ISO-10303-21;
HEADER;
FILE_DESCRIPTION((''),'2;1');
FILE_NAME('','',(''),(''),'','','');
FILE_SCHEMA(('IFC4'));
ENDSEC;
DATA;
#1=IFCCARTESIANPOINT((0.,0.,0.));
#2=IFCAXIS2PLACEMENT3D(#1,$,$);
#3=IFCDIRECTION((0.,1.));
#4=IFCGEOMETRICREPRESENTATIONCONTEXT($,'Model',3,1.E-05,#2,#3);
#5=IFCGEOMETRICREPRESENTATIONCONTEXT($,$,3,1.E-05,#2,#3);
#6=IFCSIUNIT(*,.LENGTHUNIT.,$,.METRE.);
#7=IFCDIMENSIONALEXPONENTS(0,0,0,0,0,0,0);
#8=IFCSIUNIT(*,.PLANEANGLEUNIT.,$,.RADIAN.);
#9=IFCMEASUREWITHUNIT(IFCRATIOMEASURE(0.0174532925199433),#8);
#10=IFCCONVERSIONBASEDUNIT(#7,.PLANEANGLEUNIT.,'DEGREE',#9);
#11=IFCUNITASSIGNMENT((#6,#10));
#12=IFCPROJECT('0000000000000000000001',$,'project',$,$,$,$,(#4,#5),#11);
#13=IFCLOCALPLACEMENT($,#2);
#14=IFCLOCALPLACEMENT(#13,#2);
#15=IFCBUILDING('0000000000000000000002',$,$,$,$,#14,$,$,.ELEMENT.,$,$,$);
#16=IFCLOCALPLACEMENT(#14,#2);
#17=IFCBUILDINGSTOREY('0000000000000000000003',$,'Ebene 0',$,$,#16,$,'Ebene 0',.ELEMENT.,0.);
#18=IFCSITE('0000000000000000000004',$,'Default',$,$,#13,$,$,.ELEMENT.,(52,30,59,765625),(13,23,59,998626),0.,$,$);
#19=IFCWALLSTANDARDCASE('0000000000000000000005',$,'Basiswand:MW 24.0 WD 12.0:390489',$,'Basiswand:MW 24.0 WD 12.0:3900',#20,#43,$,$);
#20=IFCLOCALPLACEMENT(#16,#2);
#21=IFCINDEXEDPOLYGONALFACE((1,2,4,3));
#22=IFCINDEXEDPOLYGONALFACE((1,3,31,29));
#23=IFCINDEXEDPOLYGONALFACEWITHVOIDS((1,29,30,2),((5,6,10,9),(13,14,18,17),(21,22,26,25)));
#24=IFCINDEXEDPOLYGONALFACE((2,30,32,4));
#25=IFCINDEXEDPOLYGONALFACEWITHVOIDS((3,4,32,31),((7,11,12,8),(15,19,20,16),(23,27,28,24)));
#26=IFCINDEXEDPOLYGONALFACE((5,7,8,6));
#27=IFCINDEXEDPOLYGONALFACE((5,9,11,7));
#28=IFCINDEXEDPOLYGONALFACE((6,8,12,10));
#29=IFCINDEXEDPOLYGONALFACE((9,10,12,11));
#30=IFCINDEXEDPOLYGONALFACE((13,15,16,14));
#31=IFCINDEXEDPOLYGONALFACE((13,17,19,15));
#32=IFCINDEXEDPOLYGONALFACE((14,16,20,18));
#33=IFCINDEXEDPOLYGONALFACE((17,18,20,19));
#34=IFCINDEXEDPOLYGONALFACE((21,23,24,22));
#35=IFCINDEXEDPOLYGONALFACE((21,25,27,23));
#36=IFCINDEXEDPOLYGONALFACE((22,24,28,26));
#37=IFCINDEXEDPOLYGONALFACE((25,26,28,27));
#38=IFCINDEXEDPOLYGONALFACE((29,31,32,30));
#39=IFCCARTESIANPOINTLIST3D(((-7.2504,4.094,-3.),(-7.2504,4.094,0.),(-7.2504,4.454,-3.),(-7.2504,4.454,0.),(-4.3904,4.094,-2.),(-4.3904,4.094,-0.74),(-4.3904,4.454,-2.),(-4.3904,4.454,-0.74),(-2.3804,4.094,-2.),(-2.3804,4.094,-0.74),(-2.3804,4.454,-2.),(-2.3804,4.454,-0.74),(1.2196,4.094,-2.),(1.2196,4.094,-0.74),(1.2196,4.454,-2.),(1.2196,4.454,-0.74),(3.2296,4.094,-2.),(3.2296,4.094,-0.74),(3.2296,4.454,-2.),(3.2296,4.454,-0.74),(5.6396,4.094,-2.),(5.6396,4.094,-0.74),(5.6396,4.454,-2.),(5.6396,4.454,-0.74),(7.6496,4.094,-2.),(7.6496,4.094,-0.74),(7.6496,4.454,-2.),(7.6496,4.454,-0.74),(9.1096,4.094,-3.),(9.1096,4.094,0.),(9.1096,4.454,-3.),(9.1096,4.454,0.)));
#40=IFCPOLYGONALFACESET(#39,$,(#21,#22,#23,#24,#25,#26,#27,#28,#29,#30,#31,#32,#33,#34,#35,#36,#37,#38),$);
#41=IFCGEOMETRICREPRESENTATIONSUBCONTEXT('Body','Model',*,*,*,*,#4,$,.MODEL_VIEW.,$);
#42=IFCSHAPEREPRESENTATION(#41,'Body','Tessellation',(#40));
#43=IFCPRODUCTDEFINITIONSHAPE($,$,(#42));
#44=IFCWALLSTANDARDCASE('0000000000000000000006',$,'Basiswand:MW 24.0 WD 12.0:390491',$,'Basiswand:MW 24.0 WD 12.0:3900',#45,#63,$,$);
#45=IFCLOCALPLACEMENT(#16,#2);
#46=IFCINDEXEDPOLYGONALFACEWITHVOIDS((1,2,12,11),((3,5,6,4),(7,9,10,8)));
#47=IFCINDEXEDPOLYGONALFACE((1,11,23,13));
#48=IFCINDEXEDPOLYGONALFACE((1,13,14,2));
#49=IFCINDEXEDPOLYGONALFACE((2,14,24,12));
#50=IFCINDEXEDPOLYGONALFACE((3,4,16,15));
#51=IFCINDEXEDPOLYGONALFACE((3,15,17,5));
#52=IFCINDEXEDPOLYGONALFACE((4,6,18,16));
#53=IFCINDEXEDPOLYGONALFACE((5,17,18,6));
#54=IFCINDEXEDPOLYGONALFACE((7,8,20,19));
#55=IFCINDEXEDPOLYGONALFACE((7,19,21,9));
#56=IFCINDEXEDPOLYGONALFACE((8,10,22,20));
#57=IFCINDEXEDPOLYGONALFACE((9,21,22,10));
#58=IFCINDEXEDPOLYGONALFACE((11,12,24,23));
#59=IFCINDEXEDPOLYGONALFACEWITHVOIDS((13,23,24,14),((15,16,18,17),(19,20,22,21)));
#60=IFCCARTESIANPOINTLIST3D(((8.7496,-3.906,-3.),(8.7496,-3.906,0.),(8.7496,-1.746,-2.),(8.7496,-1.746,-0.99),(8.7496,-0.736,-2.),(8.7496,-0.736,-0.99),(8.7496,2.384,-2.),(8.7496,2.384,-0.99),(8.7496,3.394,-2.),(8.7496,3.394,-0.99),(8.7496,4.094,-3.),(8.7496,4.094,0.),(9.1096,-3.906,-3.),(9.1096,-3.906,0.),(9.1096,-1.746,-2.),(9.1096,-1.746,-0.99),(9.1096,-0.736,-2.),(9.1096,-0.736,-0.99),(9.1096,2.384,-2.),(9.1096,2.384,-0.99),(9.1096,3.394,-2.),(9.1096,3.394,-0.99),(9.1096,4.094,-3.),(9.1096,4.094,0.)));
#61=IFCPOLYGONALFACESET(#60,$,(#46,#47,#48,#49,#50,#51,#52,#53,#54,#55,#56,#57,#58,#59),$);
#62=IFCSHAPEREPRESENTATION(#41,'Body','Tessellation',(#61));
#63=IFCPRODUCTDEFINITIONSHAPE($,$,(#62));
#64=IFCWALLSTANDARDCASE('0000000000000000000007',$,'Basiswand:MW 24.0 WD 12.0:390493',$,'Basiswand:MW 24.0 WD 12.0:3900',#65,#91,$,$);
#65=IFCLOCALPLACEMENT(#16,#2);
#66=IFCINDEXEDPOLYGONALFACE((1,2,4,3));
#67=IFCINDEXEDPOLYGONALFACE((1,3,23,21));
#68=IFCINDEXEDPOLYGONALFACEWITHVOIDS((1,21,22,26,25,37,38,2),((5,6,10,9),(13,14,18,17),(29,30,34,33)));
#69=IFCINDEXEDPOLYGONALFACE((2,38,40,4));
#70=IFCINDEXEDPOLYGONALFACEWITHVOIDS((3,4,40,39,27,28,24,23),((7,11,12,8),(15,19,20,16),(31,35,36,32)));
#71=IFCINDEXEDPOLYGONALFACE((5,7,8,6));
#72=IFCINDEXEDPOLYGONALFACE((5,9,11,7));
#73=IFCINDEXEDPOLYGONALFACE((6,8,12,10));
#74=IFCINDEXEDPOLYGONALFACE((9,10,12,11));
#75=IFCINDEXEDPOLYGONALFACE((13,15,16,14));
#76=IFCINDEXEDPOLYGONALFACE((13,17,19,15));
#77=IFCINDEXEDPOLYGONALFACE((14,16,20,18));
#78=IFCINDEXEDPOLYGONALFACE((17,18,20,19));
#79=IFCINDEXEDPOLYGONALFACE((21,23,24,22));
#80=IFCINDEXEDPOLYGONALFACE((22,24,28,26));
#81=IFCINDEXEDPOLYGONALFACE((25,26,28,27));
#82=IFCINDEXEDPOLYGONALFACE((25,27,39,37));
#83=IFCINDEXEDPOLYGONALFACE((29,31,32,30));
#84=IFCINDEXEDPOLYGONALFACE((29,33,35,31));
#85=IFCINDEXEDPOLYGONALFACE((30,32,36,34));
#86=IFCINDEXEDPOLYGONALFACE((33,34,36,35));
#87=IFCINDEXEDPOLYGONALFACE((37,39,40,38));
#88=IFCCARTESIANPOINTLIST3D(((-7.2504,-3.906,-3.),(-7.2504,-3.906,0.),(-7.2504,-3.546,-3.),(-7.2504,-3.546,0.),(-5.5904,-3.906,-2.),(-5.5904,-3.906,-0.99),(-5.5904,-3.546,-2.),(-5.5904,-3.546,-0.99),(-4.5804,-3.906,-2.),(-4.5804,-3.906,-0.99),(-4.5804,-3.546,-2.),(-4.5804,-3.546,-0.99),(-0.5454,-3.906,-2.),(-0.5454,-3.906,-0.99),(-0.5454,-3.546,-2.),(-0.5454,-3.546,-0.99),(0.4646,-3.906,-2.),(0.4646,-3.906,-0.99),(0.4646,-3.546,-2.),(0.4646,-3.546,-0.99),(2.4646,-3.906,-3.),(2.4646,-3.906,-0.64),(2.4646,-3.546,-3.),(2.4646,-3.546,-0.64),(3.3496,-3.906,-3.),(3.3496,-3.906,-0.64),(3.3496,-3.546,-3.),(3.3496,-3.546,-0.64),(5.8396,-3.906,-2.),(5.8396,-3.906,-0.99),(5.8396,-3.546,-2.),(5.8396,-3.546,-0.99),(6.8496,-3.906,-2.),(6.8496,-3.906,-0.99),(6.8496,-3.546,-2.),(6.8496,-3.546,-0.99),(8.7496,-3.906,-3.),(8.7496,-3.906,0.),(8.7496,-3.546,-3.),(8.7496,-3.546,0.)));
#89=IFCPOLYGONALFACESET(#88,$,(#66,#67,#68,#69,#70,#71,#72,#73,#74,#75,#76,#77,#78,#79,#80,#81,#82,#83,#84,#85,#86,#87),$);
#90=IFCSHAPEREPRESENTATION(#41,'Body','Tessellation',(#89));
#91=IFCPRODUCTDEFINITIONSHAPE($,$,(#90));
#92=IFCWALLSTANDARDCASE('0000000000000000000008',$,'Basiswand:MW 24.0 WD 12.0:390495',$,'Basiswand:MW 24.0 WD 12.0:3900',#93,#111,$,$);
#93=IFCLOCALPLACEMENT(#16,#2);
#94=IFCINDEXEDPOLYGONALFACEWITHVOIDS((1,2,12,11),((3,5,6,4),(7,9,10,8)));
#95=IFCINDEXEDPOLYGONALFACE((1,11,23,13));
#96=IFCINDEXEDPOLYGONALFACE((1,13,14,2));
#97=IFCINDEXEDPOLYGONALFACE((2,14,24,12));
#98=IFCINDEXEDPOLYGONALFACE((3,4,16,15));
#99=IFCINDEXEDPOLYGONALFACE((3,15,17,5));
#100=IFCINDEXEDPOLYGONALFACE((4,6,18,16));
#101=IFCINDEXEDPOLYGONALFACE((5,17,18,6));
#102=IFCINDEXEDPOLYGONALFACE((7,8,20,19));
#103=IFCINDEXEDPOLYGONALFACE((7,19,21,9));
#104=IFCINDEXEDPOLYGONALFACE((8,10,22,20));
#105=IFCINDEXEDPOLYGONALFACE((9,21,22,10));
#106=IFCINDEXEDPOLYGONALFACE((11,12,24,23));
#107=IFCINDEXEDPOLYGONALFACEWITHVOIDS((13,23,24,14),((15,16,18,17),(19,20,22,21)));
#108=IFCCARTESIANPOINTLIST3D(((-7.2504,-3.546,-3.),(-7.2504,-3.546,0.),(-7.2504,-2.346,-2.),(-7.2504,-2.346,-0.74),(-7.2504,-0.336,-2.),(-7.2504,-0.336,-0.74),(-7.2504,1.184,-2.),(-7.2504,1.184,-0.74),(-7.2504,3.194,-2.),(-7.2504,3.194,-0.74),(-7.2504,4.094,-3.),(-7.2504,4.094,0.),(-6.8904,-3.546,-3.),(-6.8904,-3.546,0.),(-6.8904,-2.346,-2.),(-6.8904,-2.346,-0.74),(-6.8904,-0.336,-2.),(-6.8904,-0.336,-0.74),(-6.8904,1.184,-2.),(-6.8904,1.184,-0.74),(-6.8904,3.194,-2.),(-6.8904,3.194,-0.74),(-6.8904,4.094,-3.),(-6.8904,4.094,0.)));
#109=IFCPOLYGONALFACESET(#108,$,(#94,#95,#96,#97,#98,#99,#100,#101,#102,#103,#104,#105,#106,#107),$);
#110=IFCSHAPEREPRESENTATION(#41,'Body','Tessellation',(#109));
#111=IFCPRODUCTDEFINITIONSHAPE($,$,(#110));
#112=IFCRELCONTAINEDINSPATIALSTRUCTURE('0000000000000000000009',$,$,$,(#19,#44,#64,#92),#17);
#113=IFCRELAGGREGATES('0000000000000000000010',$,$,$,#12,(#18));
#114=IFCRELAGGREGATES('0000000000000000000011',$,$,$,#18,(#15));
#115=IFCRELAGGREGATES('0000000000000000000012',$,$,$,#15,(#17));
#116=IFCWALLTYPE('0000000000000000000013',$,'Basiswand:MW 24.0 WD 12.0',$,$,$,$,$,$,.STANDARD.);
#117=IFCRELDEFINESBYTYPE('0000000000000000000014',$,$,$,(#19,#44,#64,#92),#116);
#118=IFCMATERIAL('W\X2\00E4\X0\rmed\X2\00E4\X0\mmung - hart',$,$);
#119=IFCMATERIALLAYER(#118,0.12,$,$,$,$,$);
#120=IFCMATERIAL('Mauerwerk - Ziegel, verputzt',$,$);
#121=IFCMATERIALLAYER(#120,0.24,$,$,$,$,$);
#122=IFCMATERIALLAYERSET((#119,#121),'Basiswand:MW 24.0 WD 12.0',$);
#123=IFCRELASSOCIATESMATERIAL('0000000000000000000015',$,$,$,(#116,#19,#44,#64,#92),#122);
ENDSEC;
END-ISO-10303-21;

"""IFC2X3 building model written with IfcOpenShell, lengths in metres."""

from ifc_helpers import new_model, entity, si_unit, converted_unit, direction, frame, frame_2d, origin, place, context, subcontext, project, spatial, rectangle, extrude, material, layer, layer_set, layer_usage, type_object, element, save


model = new_model("IFC2X3")

# Units and contexts
model_context = context("Model", 3, precision=1e-05, world=origin(), true_north=direction((0.0, 1.0)))
context_of_model = context(None, 3, precision=1e-05, world=origin(), true_north=direction((0.0, 1.0)))
body_context = subcontext(model_context, "Body", "Model", "MODEL_VIEW")
ifc_project = project(units=[si_unit("LENGTHUNIT", "METRE"), converted_unit("PLANEANGLEUNIT", "DEGREE", entity("IfcRatioMeasure", 0.0174532925199433), si_unit("PLANEANGLEUNIT", "RADIAN"), dimensions=[0, 0, 0, 0, 0, 0, 0])], contexts=[model_context, context_of_model])

# Site, building, storey
site_placement = place(None, origin())
site = spatial("IfcSite", under=ifc_project, at=site_placement, Name="Default", CompositionType="ELEMENT", RefLatitude=(52, 30, 59, 765625), RefLongitude=(13, 23, 59, 998626), RefElevation=0.0)
building_placement = place(site_placement, origin())
building = spatial("IfcBuilding", under=site, at=building_placement, CompositionType="ELEMENT")
storey_placement = place(building_placement, origin())
storey = spatial("IfcBuildingStorey", under=building, at=storey_placement, Name="Ebene 0", LongName="Ebene 0", CompositionType="ELEMENT", Elevation=0.0)

# Walls, openings
ifc_material_1 = material(Name="Wärmedämmung - hart")
ifc_layer_1 = layer(ifc_material_1, 0.12)
ifc_material_2 = material(Name="Mauerwerk - Ziegel, verputzt")
ifc_layer_2 = layer(ifc_material_2, 0.24)
ifc_layer_set = layer_set([ifc_layer_1, ifc_layer_2], Name="Basiswand:MW 24.0 WD 12.0")
ifc_layer_usage_1 = layer_usage(ifc_layer_set, "AXIS2", "NEGATIVE", 0.18)
wall_type = type_object("IfcWallType", Name="Basiswand:MW 24.0 WD 12.0", PredefinedType="STANDARD", material=ifc_layer_set)
wall_1_placement = place(storey_placement, frame((-7.2504, 4.274, -3.0)))
wall_1 = element("IfcWallStandardCase", 1, at=wall_1_placement, inside=storey, type_object=wall_type, material=ifc_layer_usage_1, Name="Basiswand:MW 24.0 WD 12.0:390489", ObjectType="Basiswand:MW 24.0 WD 12.0:3900", context=body_context, shape_type="SweptSolid", body=[
    extrude(rectangle(XDim=16.36, YDim=0.36, at=frame_2d((8.18, 0.0), x_axis=(-1.0, 0.0))), origin(), (0.0, 0.0, 1.0), 3.0),
])
opening_1_placement = place(wall_1_placement, frame((2.86, -0.18, 1.0)))
element("IfcOpeningElement", 2, at=opening_1_placement, cuts=wall_1, ObjectType="Opening", context=body_context, shape_type="SweptSolid", body=[
    extrude(rectangle(XDim=1.26, YDim=2.01, at=frame_2d((0.63, 1.005), x_axis=(1.0, 0.0))), frame((0.0, 0.0, 0.0), z_axis=(0.0, 1.0, 0.0), x_axis=(0.0, 0.0, 1.0)), (0.0, 0.0, 1.0), 0.36),
])
opening_2_placement = place(wall_1_placement, frame((8.47, -0.18, 1.0)))
element("IfcOpeningElement", 3, at=opening_2_placement, cuts=wall_1, ObjectType="Opening", context=body_context, shape_type="SweptSolid", body=[
    extrude(rectangle(XDim=1.26, YDim=2.01, at=frame_2d((0.63, 1.005), x_axis=(1.0, 0.0))), frame((0.0, 0.0, 0.0), z_axis=(0.0, 1.0, 0.0), x_axis=(0.0, 0.0, 1.0)), (0.0, 0.0, 1.0), 0.36),
])
opening_3_placement = place(wall_1_placement, frame((12.89, -0.18, 1.0)))
element("IfcOpeningElement", 4, at=opening_3_placement, cuts=wall_1, ObjectType="Opening", context=body_context, shape_type="SweptSolid", body=[
    extrude(rectangle(XDim=1.26, YDim=2.01, at=frame_2d((0.63, 1.005), x_axis=(1.0, 0.0))), frame((0.0, 0.0, 0.0), z_axis=(0.0, 1.0, 0.0), x_axis=(0.0, 0.0, 1.0)), (0.0, 0.0, 1.0), 0.36),
])
ifc_layer_usage_2 = layer_usage(ifc_layer_set, "AXIS2", "NEGATIVE", 0.18)
wall_2_placement = place(storey_placement, frame((8.9296, 4.094, -3.0), z_axis=(0.0, 0.0, 1.0), x_axis=(0.0, -1.0, 0.0)))
wall_2 = element("IfcWallStandardCase", 5, at=wall_2_placement, inside=storey, type_object=wall_type, material=ifc_layer_usage_2, Name="Basiswand:MW 24.0 WD 12.0:390491", ObjectType="Basiswand:MW 24.0 WD 12.0:3900", context=body_context, shape_type="SweptSolid", body=[
    extrude(rectangle(XDim=8.0, YDim=0.36, at=frame_2d((4.0, 0.0), x_axis=(-1.0, 0.0))), origin(), (0.0, 0.0, 1.0), 3.0),
])
opening_4_placement = place(wall_2_placement, frame((4.83, -0.18, 1.0)))
element("IfcOpeningElement", 6, at=opening_4_placement, cuts=wall_2, ObjectType="Opening", context=body_context, shape_type="SweptSolid", body=[
    extrude(rectangle(XDim=1.01, YDim=1.01, at=frame_2d((0.505, 0.505), x_axis=(1.0, 0.0))), frame((0.0, 0.0, 0.0), z_axis=(0.0, 1.0, 0.0), x_axis=(0.0, 0.0, 1.0)), (0.0, 0.0, 1.0), 0.36),
])
opening_5_placement = place(wall_2_placement, frame((0.7, -0.18, 1.0)))
element("IfcOpeningElement", 7, at=opening_5_placement, cuts=wall_2, ObjectType="Opening", context=body_context, shape_type="SweptSolid", body=[
    extrude(rectangle(XDim=1.01, YDim=1.01, at=frame_2d((0.505, 0.505), x_axis=(1.0, 0.0))), frame((0.0, 0.0, 0.0), z_axis=(0.0, 1.0, 0.0), x_axis=(0.0, 0.0, 1.0)), (0.0, 0.0, 1.0), 0.36),
])
ifc_layer_usage_3 = layer_usage(ifc_layer_set, "AXIS2", "NEGATIVE", 0.18)
wall_3_placement = place(storey_placement, frame((8.7496, -3.726, -3.0), z_axis=(0.0, 0.0, 1.0), x_axis=(-1.0, 0.0, 0.0)))
wall_3 = element("IfcWallStandardCase", 8, at=wall_3_placement, inside=storey, type_object=wall_type, material=ifc_layer_usage_3, Name="Basiswand:MW 24.0 WD 12.0:390493", ObjectType="Basiswand:MW 24.0 WD 12.0:3900", context=body_context, shape_type="SweptSolid", body=[
    extrude(rectangle(XDim=16.0, YDim=0.36, at=frame_2d((8.0, 0.0), x_axis=(-1.0, 0.0))), origin(), (0.0, 0.0, 1.0), 3.0),
])
opening_6_placement = place(wall_3_placement, frame((5.4, -0.18, 0.0)))
element("IfcOpeningElement", 9, at=opening_6_placement, cuts=wall_3, ObjectType="Opening", context=body_context, shape_type="SweptSolid", body=[
    extrude(rectangle(XDim=2.36, YDim=0.885, at=frame_2d((1.18, 0.4425), x_axis=(1.0, 0.0))), frame((0.0, 0.0, 0.0), z_axis=(0.0, 1.0, 0.0), x_axis=(0.0, 0.0, 1.0)), (0.0, 0.0, 1.0), 0.36),
])
opening_7_placement = place(wall_3_placement, frame((1.9, -0.18, 1.0)))
element("IfcOpeningElement", 10, at=opening_7_placement, cuts=wall_3, ObjectType="Opening", context=body_context, shape_type="SweptSolid", body=[
    extrude(rectangle(XDim=1.01, YDim=1.01, at=frame_2d((0.505, 0.505), x_axis=(1.0, 0.0))), frame((0.0, 0.0, 0.0), z_axis=(0.0, 1.0, 0.0), x_axis=(0.0, 0.0, 1.0)), (0.0, 0.0, 1.0), 0.36),
])
opening_8_placement = place(wall_3_placement, frame((8.285, -0.18, 1.0)))
element("IfcOpeningElement", 11, at=opening_8_placement, cuts=wall_3, ObjectType="Opening", context=body_context, shape_type="SweptSolid", body=[
    extrude(rectangle(XDim=1.01, YDim=1.01, at=frame_2d((0.505, 0.505), x_axis=(1.0, 0.0))), frame((0.0, 0.0, 0.0), z_axis=(0.0, 1.0, 0.0), x_axis=(0.0, 0.0, 1.0)), (0.0, 0.0, 1.0), 0.36),
])
opening_9_placement = place(wall_3_placement, frame((13.33, -0.18, 1.0)))
element("IfcOpeningElement", 12, at=opening_9_placement, cuts=wall_3, ObjectType="Opening", context=body_context, shape_type="SweptSolid", body=[
    extrude(rectangle(XDim=1.01, YDim=1.01, at=frame_2d((0.505, 0.505), x_axis=(1.0, 0.0))), frame((0.0, 0.0, 0.0), z_axis=(0.0, 1.0, 0.0), x_axis=(0.0, 0.0, 1.0)), (0.0, 0.0, 1.0), 0.36),
])
ifc_layer_usage_4 = layer_usage(ifc_layer_set, "AXIS2", "NEGATIVE", 0.18)
wall_4_placement = place(storey_placement, frame((-7.0704, -3.546, -3.0), z_axis=(0.0, 0.0, 1.0), x_axis=(0.0, 1.0, 0.0)))
wall_4 = element("IfcWallStandardCase", 13, at=wall_4_placement, inside=storey, type_object=wall_type, material=ifc_layer_usage_4, Name="Basiswand:MW 24.0 WD 12.0:390495", ObjectType="Basiswand:MW 24.0 WD 12.0:3900", context=body_context, shape_type="SweptSolid", body=[
    extrude(rectangle(XDim=7.64, YDim=0.36, at=frame_2d((3.82, 0.0), x_axis=(-1.0, 0.0))), origin(), (0.0, 0.0, 1.0), 3.0),
])
opening_10_placement = place(wall_4_placement, frame((1.2, -0.18, 1.0)))
element("IfcOpeningElement", 14, at=opening_10_placement, cuts=wall_4, ObjectType="Opening", context=body_context, shape_type="SweptSolid", body=[
    extrude(rectangle(XDim=1.26, YDim=2.01, at=frame_2d((0.63, 1.005), x_axis=(1.0, 0.0))), frame((0.0, 0.0, 0.0), z_axis=(0.0, 1.0, 0.0), x_axis=(0.0, 0.0, 1.0)), (0.0, 0.0, 1.0), 0.36),
])
opening_11_placement = place(wall_4_placement, frame((4.73, -0.18, 1.0)))
element("IfcOpeningElement", 15, at=opening_11_placement, cuts=wall_4, ObjectType="Opening", context=body_context, shape_type="SweptSolid", body=[
    extrude(rectangle(XDim=1.26, YDim=2.01, at=frame_2d((0.63, 1.005), x_axis=(1.0, 0.0))), frame((0.0, 0.0, 0.0), z_axis=(0.0, 1.0, 0.0), x_axis=(0.0, 0.0, 1.0)), (0.0, 0.0, 1.0), 0.36),
])

save(model, "model.ifc")
